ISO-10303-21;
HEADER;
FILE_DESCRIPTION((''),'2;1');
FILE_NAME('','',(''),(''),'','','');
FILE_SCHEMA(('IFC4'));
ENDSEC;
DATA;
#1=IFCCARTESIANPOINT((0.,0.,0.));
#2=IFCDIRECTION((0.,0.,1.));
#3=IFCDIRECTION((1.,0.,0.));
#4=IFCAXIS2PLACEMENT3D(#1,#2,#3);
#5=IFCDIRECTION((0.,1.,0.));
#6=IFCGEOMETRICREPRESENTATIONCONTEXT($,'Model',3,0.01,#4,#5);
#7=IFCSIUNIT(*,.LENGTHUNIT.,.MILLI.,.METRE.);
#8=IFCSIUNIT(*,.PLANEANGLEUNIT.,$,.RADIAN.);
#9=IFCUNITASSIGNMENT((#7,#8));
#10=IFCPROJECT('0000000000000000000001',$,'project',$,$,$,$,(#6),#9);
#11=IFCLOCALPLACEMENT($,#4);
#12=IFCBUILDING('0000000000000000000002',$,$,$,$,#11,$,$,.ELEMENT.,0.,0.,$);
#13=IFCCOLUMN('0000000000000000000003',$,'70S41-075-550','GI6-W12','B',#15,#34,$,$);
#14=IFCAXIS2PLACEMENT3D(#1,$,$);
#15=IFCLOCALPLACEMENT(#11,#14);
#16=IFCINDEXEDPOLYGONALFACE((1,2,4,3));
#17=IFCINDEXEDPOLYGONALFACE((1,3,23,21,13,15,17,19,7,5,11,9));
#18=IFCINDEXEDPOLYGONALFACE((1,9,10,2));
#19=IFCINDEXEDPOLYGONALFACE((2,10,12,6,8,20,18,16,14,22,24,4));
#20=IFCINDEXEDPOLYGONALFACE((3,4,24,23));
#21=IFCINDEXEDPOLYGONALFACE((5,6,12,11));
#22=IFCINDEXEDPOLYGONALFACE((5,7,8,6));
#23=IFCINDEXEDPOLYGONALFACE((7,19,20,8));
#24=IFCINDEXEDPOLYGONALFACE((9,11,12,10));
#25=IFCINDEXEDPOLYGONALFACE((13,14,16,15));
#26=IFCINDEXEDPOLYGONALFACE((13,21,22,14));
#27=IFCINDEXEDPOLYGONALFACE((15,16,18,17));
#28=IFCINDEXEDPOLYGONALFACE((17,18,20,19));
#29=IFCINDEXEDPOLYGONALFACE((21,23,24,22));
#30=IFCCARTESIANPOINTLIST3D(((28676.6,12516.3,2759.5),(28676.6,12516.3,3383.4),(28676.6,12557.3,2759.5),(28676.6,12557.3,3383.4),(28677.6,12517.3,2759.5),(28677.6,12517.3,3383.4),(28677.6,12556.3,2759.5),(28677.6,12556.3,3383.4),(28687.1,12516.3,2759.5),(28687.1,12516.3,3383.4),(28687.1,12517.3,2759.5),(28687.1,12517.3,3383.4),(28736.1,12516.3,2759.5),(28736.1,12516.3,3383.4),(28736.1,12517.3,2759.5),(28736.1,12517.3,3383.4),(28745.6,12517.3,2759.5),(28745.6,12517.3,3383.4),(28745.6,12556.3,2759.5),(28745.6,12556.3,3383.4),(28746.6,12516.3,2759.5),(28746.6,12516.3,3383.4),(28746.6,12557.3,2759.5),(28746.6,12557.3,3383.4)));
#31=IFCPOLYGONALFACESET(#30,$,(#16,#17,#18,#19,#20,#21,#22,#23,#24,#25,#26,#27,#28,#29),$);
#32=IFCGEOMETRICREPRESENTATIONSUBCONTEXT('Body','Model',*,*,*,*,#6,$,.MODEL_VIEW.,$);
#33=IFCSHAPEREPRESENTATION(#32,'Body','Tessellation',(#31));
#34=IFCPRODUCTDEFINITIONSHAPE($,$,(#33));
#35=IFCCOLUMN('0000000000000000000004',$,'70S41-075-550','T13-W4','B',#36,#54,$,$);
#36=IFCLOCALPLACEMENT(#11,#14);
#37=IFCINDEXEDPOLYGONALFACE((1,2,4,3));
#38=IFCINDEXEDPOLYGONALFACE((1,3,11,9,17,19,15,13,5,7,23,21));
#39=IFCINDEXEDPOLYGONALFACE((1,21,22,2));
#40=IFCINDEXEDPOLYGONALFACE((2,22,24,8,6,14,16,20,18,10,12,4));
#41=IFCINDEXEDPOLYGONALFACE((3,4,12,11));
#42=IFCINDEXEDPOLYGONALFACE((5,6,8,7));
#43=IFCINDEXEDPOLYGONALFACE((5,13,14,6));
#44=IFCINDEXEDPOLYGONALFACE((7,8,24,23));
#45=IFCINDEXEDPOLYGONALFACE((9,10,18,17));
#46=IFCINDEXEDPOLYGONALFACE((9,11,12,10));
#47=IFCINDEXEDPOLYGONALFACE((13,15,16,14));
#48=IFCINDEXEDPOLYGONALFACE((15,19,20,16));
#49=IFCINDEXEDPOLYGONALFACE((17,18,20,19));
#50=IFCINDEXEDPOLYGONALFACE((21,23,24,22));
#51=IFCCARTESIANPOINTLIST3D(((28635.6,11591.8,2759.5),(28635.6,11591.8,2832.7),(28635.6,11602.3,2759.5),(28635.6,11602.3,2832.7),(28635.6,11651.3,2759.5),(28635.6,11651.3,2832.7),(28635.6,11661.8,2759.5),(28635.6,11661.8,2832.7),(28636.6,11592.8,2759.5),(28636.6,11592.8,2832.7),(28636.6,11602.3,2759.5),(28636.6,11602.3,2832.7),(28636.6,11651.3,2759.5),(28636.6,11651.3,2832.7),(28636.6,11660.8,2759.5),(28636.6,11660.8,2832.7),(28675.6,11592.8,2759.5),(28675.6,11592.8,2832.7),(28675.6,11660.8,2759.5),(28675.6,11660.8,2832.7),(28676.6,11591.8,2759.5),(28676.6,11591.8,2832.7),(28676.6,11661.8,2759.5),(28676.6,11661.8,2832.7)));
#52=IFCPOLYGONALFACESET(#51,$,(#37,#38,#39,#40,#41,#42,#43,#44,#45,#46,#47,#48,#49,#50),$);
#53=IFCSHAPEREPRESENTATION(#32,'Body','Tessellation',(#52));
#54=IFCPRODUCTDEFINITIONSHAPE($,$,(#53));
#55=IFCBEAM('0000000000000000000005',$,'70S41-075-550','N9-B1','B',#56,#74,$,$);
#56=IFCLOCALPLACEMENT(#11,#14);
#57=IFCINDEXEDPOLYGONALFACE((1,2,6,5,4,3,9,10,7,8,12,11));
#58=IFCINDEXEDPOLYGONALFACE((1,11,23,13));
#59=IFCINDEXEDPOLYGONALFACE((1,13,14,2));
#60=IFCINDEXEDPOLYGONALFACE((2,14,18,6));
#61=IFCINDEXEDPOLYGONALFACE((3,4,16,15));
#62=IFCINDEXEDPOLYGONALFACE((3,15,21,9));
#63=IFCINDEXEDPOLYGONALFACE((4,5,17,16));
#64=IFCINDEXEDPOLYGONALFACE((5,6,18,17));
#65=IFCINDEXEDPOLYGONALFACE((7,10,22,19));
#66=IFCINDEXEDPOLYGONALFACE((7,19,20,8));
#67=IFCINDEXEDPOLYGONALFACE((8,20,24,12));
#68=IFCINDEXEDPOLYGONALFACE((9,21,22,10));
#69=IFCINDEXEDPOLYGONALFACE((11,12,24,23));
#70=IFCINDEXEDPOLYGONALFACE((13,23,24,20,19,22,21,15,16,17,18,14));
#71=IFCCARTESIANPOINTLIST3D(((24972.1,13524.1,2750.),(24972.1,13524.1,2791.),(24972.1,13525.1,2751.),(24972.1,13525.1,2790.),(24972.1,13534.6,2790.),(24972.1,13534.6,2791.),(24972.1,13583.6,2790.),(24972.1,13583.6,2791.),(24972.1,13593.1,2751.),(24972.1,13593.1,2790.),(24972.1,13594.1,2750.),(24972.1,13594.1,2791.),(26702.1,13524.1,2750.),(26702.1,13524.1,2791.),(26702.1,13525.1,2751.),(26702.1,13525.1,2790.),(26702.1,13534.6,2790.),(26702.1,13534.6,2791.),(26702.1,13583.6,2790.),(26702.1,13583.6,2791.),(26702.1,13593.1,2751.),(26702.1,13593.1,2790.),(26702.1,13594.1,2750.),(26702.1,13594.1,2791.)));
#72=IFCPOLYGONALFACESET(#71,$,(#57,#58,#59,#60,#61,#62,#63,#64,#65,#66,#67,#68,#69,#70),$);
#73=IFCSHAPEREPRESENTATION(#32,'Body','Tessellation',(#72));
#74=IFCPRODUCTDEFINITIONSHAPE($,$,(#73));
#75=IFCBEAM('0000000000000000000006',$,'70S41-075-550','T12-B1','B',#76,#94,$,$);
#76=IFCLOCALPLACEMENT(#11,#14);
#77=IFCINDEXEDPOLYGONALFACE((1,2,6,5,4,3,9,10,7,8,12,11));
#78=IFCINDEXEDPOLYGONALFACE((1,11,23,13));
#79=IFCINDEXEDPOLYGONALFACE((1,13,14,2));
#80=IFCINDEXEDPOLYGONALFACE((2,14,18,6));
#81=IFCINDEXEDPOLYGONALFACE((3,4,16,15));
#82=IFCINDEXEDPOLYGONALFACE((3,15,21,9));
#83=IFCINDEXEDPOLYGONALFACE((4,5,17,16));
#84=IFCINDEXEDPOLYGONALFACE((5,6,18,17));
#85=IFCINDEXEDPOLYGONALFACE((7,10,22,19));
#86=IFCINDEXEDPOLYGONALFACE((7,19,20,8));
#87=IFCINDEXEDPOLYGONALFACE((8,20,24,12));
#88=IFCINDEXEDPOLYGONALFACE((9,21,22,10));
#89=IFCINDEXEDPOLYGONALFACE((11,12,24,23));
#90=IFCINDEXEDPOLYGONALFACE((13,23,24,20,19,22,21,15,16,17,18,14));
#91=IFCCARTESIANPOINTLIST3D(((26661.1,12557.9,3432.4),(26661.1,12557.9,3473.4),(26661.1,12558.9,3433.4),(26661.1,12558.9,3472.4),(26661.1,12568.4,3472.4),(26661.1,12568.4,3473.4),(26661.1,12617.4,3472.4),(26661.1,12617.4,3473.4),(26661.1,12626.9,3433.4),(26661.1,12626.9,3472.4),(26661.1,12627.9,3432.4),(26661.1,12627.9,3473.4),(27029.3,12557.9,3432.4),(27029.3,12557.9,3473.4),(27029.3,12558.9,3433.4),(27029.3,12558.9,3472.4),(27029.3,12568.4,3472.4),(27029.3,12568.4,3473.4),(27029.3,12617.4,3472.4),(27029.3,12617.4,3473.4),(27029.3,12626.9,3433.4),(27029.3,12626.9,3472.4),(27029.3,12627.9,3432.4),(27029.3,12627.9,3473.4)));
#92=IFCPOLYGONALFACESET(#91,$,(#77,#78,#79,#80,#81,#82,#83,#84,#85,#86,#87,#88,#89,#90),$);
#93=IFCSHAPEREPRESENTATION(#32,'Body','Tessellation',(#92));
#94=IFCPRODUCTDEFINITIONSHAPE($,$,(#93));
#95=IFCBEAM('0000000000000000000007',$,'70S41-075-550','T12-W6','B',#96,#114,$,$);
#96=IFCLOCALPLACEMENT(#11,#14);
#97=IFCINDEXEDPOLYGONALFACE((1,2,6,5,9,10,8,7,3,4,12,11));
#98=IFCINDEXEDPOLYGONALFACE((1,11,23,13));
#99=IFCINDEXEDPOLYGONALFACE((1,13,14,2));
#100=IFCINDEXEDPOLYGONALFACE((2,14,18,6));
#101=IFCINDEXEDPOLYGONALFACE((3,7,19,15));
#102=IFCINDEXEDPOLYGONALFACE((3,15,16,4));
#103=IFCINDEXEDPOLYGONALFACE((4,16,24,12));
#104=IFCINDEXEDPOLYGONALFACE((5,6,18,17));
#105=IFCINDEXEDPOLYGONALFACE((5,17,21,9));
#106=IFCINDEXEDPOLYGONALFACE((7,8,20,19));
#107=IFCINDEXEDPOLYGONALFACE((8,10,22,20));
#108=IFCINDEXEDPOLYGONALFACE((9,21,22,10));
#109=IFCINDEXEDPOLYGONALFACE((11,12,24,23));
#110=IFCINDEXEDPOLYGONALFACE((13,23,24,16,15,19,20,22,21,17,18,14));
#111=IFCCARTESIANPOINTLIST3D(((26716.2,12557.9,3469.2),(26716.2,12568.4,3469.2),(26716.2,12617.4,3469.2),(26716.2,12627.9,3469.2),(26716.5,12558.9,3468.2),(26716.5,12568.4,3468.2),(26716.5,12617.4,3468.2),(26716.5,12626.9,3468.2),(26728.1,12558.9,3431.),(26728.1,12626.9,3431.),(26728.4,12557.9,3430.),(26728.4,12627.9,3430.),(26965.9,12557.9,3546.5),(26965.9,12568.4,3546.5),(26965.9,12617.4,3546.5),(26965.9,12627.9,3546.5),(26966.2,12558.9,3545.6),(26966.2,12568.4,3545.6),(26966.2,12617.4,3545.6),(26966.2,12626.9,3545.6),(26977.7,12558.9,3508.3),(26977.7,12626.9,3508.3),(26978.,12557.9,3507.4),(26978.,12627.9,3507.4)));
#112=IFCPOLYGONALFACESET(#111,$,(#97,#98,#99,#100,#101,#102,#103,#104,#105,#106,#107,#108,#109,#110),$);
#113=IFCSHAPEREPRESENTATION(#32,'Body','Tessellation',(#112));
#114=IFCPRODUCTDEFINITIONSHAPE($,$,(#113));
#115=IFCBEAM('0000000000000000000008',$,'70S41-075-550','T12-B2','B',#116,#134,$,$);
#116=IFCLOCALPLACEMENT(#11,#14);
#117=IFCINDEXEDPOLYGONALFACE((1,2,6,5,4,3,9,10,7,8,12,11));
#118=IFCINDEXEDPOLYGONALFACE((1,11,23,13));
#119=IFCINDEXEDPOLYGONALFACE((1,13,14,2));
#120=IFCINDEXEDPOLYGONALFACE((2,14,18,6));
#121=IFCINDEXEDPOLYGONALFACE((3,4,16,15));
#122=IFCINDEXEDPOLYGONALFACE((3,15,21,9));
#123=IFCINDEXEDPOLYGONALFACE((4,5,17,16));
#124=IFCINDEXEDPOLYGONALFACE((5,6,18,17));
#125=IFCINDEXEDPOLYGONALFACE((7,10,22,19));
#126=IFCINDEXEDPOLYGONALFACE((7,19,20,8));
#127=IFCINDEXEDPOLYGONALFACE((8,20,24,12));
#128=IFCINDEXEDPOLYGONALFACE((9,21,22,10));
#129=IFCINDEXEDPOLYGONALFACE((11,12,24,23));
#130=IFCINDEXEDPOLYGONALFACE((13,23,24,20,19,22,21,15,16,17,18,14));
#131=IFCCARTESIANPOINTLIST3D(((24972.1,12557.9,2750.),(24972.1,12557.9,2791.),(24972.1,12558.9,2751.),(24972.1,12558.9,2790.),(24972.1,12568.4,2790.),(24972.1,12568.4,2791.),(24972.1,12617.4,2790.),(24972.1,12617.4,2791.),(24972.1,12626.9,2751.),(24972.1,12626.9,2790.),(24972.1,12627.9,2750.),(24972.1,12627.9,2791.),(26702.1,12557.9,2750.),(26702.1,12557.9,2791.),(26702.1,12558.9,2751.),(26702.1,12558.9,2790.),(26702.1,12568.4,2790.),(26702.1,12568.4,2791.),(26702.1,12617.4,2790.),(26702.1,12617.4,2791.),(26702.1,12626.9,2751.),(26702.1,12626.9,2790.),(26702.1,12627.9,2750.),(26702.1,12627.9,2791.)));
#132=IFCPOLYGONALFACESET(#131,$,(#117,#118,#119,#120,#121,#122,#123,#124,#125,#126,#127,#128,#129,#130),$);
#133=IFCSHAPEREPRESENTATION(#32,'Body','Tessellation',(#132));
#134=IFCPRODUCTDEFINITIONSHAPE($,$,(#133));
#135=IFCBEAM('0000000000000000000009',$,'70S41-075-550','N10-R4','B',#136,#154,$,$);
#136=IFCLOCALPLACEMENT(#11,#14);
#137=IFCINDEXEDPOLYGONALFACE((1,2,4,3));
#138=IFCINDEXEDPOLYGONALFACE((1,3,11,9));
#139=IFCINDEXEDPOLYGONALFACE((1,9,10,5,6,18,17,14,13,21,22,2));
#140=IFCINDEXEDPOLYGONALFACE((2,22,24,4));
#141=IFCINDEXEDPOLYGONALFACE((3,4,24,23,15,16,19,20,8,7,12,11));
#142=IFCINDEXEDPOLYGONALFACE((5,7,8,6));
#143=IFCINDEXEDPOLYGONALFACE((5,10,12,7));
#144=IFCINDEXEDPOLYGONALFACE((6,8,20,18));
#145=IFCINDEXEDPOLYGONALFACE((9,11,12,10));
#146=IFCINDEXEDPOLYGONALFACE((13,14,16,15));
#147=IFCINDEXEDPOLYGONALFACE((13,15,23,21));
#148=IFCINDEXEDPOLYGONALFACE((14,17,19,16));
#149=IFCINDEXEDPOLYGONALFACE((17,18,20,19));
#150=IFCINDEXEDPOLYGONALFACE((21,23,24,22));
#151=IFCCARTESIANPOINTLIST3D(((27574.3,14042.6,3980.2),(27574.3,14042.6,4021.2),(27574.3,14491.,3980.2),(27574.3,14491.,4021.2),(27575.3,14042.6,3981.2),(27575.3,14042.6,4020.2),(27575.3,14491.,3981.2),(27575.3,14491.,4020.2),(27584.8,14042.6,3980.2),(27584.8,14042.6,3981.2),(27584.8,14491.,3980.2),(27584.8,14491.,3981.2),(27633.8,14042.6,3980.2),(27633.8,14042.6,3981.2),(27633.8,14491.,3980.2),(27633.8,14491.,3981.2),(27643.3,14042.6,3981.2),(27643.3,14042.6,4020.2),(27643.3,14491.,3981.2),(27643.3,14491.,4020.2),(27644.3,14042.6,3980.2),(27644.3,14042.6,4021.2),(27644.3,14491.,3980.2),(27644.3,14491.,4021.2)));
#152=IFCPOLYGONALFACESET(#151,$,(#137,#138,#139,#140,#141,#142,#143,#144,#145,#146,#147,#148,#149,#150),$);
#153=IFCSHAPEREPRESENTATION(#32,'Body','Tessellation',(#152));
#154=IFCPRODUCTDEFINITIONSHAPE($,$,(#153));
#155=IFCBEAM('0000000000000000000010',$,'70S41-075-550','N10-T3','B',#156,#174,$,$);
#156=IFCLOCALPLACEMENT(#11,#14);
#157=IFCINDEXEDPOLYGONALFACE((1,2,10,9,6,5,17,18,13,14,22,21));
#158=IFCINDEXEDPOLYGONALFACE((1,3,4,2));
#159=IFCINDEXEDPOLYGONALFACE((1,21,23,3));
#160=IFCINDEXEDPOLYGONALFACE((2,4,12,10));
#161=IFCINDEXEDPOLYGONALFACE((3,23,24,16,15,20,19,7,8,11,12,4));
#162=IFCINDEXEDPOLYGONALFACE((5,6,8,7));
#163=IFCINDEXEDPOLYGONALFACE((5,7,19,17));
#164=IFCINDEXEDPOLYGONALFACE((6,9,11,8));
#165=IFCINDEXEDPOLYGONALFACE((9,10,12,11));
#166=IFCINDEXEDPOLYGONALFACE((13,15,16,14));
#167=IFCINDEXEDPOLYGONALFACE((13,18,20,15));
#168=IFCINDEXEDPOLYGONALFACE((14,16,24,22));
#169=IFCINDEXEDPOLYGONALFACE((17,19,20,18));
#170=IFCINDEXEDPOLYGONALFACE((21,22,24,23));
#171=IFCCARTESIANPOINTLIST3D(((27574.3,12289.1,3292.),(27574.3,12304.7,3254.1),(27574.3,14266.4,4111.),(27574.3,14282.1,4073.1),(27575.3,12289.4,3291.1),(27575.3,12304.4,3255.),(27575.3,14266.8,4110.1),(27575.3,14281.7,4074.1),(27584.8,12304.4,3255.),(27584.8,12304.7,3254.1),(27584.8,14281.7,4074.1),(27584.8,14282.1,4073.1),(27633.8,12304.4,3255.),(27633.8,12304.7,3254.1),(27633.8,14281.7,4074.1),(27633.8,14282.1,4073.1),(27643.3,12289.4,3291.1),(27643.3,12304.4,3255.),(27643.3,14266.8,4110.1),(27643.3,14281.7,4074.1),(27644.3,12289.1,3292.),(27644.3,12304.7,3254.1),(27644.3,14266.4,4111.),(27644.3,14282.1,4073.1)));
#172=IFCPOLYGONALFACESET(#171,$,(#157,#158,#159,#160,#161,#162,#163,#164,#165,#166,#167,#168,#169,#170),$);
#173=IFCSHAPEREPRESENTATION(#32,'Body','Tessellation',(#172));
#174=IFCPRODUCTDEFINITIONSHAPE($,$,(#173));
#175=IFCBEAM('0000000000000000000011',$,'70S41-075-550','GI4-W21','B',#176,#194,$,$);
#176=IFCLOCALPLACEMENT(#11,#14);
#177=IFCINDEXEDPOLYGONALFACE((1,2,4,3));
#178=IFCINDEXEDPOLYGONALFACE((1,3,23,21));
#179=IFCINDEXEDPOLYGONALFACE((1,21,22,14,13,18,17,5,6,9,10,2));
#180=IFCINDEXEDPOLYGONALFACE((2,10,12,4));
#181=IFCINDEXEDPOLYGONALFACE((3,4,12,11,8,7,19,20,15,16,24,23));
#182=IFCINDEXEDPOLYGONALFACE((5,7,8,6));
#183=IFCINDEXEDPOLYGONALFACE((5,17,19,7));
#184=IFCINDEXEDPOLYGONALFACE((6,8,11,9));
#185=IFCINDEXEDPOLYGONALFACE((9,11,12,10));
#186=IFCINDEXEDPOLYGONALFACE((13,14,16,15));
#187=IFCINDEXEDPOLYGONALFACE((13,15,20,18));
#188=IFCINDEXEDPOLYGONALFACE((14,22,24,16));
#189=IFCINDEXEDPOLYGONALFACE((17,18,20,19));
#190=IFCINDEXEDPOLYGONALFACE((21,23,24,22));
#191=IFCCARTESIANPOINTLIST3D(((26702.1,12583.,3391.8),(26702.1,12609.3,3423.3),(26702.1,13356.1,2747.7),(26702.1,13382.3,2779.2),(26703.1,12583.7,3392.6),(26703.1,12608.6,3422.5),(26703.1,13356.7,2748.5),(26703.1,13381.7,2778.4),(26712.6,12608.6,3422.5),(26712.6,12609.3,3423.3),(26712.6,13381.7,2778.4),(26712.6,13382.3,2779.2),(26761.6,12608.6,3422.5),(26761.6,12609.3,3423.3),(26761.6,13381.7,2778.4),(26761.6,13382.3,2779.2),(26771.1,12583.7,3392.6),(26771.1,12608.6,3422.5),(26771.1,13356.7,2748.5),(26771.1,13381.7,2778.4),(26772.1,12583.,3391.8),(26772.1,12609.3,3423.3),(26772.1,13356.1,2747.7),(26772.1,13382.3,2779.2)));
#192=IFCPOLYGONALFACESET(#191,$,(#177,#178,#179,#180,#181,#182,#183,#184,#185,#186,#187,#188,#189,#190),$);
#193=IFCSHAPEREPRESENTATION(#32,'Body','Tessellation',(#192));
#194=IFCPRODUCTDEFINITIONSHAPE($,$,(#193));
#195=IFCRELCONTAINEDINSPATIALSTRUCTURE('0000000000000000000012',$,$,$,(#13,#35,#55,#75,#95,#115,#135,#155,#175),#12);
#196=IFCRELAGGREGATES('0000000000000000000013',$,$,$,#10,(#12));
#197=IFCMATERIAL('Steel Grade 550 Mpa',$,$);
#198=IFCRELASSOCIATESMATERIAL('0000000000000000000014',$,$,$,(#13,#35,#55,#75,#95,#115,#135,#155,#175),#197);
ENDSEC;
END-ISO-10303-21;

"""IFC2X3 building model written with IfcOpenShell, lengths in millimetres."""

from ifc_helpers import new_model, si_unit, direction, frame, origin, origin_with_axes, origin_2d_with_axis, place, context, subcontext, project, spatial, c_section, extrude, source, transform, mapped, material, element, save


model = new_model("IFC2X3")

# Units and contexts
model_context = context("Model", 3, precision=0.01, world=origin_with_axes(), true_north=direction((0.0, 1.0, 0.0)))
body_context = subcontext(model_context, "Body", "Model", "MODEL_VIEW")
ifc_project = project(units=[si_unit("LENGTHUNIT", "METRE", prefix="MILLI"), si_unit("PLANEANGLEUNIT", "RADIAN")], contexts=[model_context])

# Building
building_placement = place(None, origin_with_axes())
building = spatial("IfcBuilding", under=ifc_project, at=building_placement, CompositionType="ELEMENT", ElevationOfRefHeight=0.0, ElevationOfTerrain=0.0)

# Columns
ifc_material = material(Name="Steel Grade 550 Mpa")
shared_shape_1 = source(origin(), body_context, "Body", "SweptSolid", [
    extrude(c_section(Depth=70.0, Width=41.0, WallThickness=1.0, Girth=10.5, at=origin_2d_with_axis()), origin_with_axes(), (0.0, 0.0, 1.0), 623.9),
])
column_1_placement = place(None, frame((28711.6, 12536.8, 3383.4), z_axis=(0.0, 0.0, -1.0), x_axis=(0.0, -1.0, 0.0)))
element("IfcColumn", 1, at=column_1_placement, inside=building, material=ifc_material, Name="70S41-075-550", Description="GI6-W12", ObjectType="B", context=body_context, shape_type="MappedRepresentation", body=[
    mapped(shared_shape_1, transform((0.0, 0.0, 0.0), scale=1.0)),
])
shared_shape_2 = source(origin(), body_context, "Body", "SweptSolid", [
    extrude(c_section(Depth=70.0, Width=41.0, WallThickness=1.0, Girth=10.5, at=origin_2d_with_axis()), origin_with_axes(), (0.0, 0.0, 1.0), 73.2),
])
column_2_placement = place(None, frame((28656.1, 11626.8, 2832.7), z_axis=(0.0, 0.0, -1.0), x_axis=(-1.0, 0.0, 0.0)))
element("IfcColumn", 2, at=column_2_placement, inside=building, material=ifc_material, Name="70S41-075-550", Description="T13-W4", ObjectType="B", context=body_context, shape_type="MappedRepresentation", body=[
    mapped(shared_shape_2, transform((0.0, 0.0, 0.0), scale=1.0)),
])

# Beams
shared_shape_3 = source(origin(), body_context, "Body", "SweptSolid", [
    extrude(c_section(Depth=70.0, Width=41.0, WallThickness=1.0, Girth=10.5, at=origin_2d_with_axis()), origin_with_axes(), (0.0, 0.0, 1.0), 1730.0),
])
beam_1_placement = place(None, frame((26702.1, 13559.1, 2770.5), z_axis=(-1.0, 0.0, 0.0), x_axis=(0.0, 0.0, 1.0)))
element("IfcBeam", 3, at=beam_1_placement, inside=building, material=ifc_material, Name="70S41-075-550", Description="N9-B1", ObjectType="B", context=body_context, shape_type="MappedRepresentation", body=[
    mapped(shared_shape_3, transform((0.0, 0.0, 0.0), scale=1.0)),
])
shared_shape_4 = source(origin(), body_context, "Body", "SweptSolid", [
    extrude(c_section(Depth=70.0, Width=41.0, WallThickness=1.0, Girth=10.5, at=origin_2d_with_axis()), origin_with_axes(), (0.0, 0.0, 1.0), 368.2),
])
beam_2_placement = place(None, frame((27029.3, 12592.9, 3452.9), z_axis=(-1.0, 0.0, 0.0), x_axis=(0.0, 0.0, 1.0)))
element("IfcBeam", 4, at=beam_2_placement, inside=building, material=ifc_material, Name="70S41-075-550", Description="T12-B1", ObjectType="B", context=body_context, shape_type="MappedRepresentation", body=[
    mapped(shared_shape_4, transform((0.0, 0.0, 0.0), scale=1.0)),
])
shared_shape_5 = source(origin(), body_context, "Body", "SweptSolid", [
    extrude(c_section(Depth=70.0, Width=41.0, WallThickness=1.0, Girth=10.5, at=origin_2d_with_axis()), origin_with_axes(), (0.0, 0.0, 1.0), 261.3),
])
beam_3_placement = place(None, frame((26972.0, 12592.9, 3526.9), z_axis=(-0.955228, 0.0, -0.295872), x_axis=(-0.295872, 0.0, 0.955228)))
element("IfcBeam", 5, at=beam_3_placement, inside=building, material=ifc_material, Name="70S41-075-550", Description="T12-W6", ObjectType="B", context=body_context, shape_type="MappedRepresentation", body=[
    mapped(shared_shape_5, transform((0.0, 0.0, 0.0), scale=1.0)),
])
shared_shape_6 = source(origin(), body_context, "Body", "SweptSolid", [
    extrude(c_section(Depth=70.0, Width=41.0, WallThickness=1.0, Girth=10.5, at=origin_2d_with_axis()), origin_with_axes(), (0.0, 0.0, 1.0), 1730.0),
])
beam_4_placement = place(None, frame((26702.1, 12592.9, 2770.5), z_axis=(-1.0, 0.0, 0.0), x_axis=(0.0, 0.0, 1.0)))
element("IfcBeam", 6, at=beam_4_placement, inside=building, material=ifc_material, Name="70S41-075-550", Description="T12-B2", ObjectType="B", context=body_context, shape_type="MappedRepresentation", body=[
    mapped(shared_shape_6, transform((0.0, 0.0, 0.0), scale=1.0)),
])
shared_shape_7 = source(origin(), body_context, "Body", "SweptSolid", [
    extrude(c_section(Depth=70.0, Width=41.0, WallThickness=1.0, Girth=10.5, at=origin_2d_with_axis()), origin_with_axes(), (0.0, 0.0, 1.0), 448.4),
])
beam_5_placement = place(None, frame((27609.3, 14042.6, 4000.7), z_axis=(0.0, 1.0, 0.0), x_axis=(0.0, 0.0, -1.0)))
element("IfcBeam", 7, at=beam_5_placement, inside=building, material=ifc_material, Name="70S41-075-550", Description="N10-R4", ObjectType="B", context=body_context, shape_type="MappedRepresentation", body=[
    mapped(shared_shape_7, transform((0.0, 0.0, 0.0), scale=1.0)),
])
shared_shape_8 = source(origin(), body_context, "Body", "SweptSolid", [
    extrude(c_section(Depth=70.0, Width=41.0, WallThickness=1.0, Girth=10.5, at=origin_2d_with_axis()), origin_with_axes(), (0.0, 0.0, 1.0), 2140.2),
])
beam_6_placement = place(None, frame((27609.3, 12296.9, 3273.0), z_axis=(0.0, 0.92388, 0.382683), x_axis=(0.0, 0.382683, -0.92388)))
element("IfcBeam", 8, at=beam_6_placement, inside=building, material=ifc_material, Name="70S41-075-550", Description="N10-T3", ObjectType="B", context=body_context, shape_type="MappedRepresentation", body=[
    mapped(shared_shape_8, transform((0.0, 0.0, 0.0), scale=1.0)),
])
shared_shape_9 = source(origin(), body_context, "Body", "SweptSolid", [
    extrude(c_section(Depth=70.0, Width=41.0, WallThickness=1.0, Girth=10.5, at=origin_2d_with_axis()), origin_with_axes(), (0.0, 0.0, 1.0), 1006.2),
])
beam_7_placement = place(None, frame((26737.1, 13369.2, 2763.5), z_axis=(0.0, -0.768283, 0.640111), x_axis=(0.0, 0.640111, 0.768283)))
element("IfcBeam", 9, at=beam_7_placement, inside=building, material=ifc_material, Name="70S41-075-550", Description="GI4-W21", ObjectType="B", context=body_context, shape_type="MappedRepresentation", body=[
    mapped(shared_shape_9, transform((0.0, 0.0, 0.0), scale=1.0)),
])

save(model, "model.ifc")
